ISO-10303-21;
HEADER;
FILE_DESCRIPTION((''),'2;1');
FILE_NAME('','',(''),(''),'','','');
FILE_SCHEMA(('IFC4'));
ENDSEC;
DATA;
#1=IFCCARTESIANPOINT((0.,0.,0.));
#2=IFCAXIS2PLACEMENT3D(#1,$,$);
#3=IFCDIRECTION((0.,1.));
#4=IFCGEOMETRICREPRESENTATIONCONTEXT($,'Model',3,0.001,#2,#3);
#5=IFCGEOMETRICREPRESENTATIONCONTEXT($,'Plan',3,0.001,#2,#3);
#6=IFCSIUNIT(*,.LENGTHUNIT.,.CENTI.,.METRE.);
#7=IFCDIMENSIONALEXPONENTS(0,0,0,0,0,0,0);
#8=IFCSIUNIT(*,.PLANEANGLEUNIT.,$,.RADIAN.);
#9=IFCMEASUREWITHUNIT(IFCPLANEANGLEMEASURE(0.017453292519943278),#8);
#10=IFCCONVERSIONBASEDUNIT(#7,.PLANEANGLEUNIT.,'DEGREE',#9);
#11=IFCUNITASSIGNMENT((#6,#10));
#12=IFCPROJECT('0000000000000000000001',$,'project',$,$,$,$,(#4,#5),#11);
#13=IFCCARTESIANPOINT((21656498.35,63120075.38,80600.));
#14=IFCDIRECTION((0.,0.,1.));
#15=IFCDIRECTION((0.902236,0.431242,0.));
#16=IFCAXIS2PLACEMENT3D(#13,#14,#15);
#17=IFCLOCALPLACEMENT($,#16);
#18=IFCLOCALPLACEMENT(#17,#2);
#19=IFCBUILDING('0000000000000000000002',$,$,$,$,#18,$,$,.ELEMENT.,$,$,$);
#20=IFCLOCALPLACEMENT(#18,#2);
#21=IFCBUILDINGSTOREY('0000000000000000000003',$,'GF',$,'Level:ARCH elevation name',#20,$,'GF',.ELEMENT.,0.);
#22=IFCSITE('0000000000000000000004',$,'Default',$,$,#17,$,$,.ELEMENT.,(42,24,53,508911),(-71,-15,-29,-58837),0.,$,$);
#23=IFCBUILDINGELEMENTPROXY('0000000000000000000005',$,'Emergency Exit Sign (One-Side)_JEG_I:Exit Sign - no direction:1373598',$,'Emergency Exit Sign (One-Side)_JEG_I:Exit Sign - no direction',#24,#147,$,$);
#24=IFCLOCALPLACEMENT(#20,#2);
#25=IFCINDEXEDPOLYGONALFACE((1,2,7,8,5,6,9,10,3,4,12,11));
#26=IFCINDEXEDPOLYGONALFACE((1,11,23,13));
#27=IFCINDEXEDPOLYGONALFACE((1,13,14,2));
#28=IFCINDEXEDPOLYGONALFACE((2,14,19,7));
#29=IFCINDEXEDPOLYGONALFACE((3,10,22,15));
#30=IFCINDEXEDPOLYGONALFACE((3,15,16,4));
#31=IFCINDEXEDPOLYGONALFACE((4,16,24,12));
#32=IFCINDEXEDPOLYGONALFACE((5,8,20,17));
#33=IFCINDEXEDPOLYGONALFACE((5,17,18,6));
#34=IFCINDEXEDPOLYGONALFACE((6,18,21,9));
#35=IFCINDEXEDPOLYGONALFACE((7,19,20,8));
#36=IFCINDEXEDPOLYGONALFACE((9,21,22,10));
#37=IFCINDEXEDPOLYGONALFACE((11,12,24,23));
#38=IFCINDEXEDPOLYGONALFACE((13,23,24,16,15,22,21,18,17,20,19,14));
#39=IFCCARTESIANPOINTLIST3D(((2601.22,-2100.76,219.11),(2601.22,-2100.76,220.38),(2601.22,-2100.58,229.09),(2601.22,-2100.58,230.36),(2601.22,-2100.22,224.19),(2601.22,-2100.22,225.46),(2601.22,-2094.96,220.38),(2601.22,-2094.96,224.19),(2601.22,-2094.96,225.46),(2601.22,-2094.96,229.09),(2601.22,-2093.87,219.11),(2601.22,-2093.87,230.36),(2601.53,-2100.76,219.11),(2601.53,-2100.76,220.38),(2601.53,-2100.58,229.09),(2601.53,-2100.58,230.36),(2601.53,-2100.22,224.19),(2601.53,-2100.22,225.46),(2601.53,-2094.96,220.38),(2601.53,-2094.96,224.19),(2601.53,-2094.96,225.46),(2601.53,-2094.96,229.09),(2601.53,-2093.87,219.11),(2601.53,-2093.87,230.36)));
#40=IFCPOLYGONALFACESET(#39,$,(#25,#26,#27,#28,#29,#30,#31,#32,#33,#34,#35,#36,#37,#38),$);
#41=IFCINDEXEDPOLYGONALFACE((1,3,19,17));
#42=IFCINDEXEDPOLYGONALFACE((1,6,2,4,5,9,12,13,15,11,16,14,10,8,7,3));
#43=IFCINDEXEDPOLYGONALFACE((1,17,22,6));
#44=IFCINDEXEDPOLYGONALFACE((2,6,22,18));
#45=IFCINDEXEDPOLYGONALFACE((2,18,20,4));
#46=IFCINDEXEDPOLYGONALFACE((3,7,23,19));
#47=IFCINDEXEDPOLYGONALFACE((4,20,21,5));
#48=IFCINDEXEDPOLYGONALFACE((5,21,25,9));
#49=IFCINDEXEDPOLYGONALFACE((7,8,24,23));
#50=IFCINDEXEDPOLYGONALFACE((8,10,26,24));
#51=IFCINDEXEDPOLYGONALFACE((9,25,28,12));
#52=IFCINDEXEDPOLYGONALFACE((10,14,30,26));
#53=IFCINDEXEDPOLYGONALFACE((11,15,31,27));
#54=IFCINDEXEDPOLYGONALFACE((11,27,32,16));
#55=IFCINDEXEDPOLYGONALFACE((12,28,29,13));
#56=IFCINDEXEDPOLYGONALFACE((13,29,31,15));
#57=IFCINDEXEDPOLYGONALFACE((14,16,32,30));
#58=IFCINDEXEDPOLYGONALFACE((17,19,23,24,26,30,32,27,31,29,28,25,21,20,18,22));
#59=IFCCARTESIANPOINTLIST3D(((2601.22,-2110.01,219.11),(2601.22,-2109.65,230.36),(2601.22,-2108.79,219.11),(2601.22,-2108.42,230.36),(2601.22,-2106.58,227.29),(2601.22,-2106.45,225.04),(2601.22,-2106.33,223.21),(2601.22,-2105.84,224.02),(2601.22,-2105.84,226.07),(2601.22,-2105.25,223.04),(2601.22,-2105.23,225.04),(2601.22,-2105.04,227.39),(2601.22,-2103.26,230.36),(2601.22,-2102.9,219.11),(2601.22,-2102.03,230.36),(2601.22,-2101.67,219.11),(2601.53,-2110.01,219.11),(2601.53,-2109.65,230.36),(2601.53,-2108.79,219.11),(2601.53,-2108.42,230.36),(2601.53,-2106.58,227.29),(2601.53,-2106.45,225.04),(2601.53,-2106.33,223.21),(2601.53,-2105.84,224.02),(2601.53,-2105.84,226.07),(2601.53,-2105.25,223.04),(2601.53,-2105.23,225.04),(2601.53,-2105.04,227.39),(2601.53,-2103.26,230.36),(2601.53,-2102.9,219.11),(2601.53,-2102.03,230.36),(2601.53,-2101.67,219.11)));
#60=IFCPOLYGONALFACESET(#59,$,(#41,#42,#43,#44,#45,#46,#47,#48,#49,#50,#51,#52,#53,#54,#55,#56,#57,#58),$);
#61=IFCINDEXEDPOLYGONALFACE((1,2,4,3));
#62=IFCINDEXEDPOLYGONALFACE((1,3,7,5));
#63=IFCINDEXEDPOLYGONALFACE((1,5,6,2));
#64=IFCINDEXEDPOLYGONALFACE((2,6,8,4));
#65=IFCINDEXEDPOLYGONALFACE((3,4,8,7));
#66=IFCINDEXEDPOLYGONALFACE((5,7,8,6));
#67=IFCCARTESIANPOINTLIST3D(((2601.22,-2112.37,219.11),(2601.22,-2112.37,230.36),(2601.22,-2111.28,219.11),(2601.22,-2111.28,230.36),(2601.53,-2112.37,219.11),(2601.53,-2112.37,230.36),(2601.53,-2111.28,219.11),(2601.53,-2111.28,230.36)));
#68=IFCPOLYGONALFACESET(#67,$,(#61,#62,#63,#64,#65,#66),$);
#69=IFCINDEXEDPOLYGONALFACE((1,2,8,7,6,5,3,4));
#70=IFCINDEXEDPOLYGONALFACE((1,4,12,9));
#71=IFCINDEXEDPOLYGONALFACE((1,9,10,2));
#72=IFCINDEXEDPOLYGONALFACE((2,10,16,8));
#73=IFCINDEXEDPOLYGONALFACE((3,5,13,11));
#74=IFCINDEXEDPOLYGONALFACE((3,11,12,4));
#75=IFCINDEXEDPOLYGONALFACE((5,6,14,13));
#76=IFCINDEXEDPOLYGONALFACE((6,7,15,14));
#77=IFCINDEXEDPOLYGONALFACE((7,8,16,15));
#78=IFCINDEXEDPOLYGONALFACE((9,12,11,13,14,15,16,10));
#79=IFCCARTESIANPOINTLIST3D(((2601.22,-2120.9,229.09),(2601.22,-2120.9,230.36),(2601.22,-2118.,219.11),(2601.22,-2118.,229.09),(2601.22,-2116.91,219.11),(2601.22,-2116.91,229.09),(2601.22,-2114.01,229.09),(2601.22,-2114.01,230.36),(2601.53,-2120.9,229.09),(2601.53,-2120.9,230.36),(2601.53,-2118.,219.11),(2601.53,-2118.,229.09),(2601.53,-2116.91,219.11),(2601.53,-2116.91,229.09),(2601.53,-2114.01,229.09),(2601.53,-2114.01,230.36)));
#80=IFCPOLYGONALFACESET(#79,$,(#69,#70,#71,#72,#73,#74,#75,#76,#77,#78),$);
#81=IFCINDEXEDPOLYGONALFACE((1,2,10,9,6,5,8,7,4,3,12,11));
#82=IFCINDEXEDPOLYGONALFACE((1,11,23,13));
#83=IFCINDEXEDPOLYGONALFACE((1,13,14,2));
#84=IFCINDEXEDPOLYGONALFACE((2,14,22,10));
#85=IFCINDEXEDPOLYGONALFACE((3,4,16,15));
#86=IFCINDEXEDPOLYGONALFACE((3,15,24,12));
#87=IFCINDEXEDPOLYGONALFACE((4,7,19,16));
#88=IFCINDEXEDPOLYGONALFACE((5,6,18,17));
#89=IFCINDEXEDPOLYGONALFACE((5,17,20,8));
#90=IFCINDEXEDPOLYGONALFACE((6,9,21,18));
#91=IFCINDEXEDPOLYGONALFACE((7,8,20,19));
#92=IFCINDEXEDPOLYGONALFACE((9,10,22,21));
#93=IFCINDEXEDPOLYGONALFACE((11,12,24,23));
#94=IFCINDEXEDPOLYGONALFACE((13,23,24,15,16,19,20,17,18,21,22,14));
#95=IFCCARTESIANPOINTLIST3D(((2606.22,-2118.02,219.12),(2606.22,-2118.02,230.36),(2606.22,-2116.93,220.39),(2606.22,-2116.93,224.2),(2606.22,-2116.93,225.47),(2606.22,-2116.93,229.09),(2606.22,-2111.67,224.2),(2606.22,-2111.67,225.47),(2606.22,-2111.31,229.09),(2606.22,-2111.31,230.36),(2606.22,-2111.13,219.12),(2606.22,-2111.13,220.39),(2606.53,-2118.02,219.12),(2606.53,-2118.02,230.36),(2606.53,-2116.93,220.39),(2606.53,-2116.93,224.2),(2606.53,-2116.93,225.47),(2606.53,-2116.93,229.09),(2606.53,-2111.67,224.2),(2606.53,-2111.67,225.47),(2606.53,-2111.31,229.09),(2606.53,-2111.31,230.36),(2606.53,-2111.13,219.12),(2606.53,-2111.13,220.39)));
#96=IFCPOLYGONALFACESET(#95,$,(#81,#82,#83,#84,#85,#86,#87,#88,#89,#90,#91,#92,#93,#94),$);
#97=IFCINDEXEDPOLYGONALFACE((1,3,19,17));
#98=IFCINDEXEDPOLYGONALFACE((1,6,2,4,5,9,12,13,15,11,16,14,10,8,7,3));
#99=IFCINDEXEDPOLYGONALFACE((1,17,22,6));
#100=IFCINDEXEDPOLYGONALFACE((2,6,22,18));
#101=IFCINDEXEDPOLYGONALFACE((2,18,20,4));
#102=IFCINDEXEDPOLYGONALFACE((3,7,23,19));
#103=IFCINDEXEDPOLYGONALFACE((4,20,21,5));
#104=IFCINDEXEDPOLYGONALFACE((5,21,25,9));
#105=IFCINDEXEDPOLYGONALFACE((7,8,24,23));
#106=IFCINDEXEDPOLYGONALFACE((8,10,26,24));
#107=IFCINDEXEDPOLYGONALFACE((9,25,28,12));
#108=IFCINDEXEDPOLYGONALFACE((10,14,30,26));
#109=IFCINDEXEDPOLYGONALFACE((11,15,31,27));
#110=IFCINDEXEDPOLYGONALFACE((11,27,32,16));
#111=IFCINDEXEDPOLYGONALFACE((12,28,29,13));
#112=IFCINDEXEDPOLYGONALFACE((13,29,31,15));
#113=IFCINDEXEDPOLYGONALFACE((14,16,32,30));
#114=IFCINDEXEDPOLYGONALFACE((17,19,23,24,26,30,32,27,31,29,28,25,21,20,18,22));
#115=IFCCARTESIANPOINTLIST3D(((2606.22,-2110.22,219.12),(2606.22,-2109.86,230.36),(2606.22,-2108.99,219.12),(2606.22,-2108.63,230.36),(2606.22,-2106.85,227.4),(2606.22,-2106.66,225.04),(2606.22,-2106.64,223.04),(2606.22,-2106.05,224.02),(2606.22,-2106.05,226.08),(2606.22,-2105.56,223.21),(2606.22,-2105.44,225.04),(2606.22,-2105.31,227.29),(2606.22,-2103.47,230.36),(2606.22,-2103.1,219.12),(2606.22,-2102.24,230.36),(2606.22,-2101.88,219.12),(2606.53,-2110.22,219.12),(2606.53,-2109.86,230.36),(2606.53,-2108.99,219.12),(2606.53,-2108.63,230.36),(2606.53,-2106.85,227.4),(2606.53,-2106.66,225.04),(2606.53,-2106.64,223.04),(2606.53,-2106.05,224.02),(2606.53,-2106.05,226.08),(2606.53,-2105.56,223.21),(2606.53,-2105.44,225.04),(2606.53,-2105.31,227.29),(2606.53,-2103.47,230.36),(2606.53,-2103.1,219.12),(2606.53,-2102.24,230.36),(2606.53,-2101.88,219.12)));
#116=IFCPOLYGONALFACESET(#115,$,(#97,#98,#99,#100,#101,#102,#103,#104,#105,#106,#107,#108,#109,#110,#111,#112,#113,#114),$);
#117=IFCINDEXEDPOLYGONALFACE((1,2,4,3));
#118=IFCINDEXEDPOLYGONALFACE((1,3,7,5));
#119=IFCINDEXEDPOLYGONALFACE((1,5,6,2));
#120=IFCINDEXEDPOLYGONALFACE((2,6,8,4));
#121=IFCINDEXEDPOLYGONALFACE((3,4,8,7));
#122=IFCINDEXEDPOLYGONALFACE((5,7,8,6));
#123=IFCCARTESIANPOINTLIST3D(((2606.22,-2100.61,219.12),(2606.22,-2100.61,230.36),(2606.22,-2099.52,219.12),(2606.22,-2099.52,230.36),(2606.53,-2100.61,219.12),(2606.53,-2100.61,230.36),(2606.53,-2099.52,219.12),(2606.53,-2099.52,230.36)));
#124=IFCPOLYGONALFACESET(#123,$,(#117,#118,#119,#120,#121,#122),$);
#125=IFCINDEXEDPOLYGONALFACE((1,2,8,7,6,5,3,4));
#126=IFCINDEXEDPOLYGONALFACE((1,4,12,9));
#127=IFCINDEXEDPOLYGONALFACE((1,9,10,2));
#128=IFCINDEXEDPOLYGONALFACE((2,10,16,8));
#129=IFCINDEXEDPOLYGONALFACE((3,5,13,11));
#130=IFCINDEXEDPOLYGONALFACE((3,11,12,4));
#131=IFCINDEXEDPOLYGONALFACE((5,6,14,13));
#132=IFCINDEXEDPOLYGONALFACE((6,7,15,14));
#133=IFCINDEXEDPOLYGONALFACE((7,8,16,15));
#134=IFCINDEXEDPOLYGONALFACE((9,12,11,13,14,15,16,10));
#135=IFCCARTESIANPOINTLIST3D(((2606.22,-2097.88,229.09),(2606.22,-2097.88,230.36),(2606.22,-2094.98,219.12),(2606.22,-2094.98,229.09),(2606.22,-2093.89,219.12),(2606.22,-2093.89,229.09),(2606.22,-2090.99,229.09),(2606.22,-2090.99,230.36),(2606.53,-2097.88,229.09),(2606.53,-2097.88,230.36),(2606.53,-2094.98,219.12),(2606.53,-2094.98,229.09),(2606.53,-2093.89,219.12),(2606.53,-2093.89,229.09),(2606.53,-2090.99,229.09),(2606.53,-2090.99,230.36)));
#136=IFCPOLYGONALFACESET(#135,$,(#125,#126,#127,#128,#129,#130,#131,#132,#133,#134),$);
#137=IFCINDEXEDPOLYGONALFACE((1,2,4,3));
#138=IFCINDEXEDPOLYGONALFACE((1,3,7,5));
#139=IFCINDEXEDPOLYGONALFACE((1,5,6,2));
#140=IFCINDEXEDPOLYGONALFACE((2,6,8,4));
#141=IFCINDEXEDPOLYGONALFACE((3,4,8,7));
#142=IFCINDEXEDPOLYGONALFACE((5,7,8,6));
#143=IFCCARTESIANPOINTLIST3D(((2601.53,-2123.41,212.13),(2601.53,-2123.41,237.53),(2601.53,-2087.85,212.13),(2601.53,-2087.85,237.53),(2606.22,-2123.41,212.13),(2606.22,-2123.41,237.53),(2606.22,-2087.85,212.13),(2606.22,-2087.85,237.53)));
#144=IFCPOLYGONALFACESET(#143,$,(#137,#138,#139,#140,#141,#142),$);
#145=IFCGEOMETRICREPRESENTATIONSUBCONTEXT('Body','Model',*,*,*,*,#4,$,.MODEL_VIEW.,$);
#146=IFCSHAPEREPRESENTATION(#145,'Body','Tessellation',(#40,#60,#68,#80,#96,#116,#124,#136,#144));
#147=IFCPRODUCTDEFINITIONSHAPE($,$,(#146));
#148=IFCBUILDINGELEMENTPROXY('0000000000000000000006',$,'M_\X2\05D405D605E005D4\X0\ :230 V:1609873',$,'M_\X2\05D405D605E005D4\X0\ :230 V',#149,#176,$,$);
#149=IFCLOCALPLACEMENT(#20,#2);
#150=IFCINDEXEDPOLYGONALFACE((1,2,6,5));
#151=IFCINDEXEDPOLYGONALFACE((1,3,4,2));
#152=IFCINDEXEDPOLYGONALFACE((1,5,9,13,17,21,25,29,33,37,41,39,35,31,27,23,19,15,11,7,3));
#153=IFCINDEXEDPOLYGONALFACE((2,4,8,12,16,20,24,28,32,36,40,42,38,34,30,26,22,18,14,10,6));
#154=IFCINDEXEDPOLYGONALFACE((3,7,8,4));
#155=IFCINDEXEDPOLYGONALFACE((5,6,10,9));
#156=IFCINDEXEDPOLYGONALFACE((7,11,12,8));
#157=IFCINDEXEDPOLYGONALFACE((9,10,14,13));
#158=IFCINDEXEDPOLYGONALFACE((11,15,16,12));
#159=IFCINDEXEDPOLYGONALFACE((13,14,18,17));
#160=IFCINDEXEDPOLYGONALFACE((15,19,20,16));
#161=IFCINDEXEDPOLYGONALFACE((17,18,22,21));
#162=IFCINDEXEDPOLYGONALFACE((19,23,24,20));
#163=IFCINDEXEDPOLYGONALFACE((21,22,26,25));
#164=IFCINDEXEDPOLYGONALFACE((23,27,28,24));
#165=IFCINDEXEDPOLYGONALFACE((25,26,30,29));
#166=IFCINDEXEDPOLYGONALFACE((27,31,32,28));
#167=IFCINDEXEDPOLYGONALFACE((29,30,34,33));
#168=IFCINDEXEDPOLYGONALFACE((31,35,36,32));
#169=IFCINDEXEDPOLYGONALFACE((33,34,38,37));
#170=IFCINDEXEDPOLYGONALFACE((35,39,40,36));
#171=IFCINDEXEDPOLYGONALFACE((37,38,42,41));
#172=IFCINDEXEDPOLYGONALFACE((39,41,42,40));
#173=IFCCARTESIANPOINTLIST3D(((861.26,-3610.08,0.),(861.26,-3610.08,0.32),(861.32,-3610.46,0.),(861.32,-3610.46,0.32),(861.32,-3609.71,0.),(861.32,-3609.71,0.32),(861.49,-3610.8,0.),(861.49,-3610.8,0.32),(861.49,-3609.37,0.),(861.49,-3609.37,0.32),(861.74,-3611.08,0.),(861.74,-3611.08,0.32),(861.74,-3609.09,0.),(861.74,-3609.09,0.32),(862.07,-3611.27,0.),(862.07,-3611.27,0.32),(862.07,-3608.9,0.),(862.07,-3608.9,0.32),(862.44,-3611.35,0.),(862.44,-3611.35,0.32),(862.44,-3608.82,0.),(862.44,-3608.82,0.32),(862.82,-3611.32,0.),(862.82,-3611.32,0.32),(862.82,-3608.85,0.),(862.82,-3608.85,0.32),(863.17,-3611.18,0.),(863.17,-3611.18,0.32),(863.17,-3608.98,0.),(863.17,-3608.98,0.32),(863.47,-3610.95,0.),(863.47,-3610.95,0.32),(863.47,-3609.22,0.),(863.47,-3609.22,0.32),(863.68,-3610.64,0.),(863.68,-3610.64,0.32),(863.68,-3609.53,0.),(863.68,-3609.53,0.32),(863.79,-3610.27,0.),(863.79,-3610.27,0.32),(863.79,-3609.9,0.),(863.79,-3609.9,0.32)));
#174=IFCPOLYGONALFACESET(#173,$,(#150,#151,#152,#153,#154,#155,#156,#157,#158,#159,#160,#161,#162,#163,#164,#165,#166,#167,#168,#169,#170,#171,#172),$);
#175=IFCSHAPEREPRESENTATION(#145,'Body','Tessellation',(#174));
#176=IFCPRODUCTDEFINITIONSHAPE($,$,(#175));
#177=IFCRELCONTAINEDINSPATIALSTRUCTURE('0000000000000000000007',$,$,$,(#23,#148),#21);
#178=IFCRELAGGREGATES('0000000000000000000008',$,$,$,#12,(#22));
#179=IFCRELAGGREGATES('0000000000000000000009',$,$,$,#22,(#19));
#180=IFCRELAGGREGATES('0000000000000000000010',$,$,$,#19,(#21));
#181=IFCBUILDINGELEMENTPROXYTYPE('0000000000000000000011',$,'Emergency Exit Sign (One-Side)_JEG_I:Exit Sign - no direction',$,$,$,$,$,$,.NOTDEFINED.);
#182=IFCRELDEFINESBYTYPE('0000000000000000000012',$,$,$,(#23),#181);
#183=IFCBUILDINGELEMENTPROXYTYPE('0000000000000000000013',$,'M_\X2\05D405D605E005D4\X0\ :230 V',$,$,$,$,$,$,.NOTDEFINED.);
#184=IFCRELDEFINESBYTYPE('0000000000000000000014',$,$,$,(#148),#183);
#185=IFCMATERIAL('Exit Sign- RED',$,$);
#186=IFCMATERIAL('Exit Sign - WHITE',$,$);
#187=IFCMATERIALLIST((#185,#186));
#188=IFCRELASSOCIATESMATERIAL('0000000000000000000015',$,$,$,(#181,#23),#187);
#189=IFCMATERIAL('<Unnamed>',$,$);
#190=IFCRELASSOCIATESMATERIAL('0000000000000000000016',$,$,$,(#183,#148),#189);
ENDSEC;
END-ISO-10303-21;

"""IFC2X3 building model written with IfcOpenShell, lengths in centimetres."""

from ifc_helpers import new_model, entity, si_unit, converted_unit, direction, frame, frame_2d, origin, origin_2d_with_axis, place, context, subcontext, project, spatial, polyline, rectangle, circle, outline, extrude, source, transform, mapped, material, material_list, type_object, type_shapes, element, save


model = new_model("IFC2X3")

# Units and contexts
model_context = context("Model", 3, precision=0.001, world=origin(), true_north=direction((0.0, 1.0)))
plan_context = context("Plan", 3, precision=0.001, world=origin(), true_north=direction((0.0, 1.0)))
body_context = subcontext(model_context, "Body", "Model", "MODEL_VIEW")
ifc_project = project(units=[si_unit("LENGTHUNIT", "METRE", prefix="CENTI"), converted_unit("PLANEANGLEUNIT", "DEGREE", entity("IfcPlaneAngleMeasure", 0.017453292519943278), si_unit("PLANEANGLEUNIT", "RADIAN"), dimensions=[0, 0, 0, 0, 0, 0, 0])], contexts=[model_context, plan_context])

# Site, building, storey
site_placement = place(None, frame((21656498.35, 63120075.38, 80600.0), z_axis=(0.0, 0.0, 1.0), x_axis=(0.902236, 0.431242, 0.0)))
site = spatial("IfcSite", under=ifc_project, at=site_placement, Name="Default", CompositionType="ELEMENT", RefLatitude=(42, 24, 53, 508911), RefLongitude=(-71, -15, -29, -58837), RefElevation=0.0)
building_placement = place(site_placement, origin())
building = spatial("IfcBuilding", under=site, at=building_placement, CompositionType="ELEMENT")
storey_placement = place(building_placement, origin())
storey = spatial("IfcBuildingStorey", under=building, at=storey_placement, Name="GF", ObjectType="Level:ARCH elevation name", LongName="GF", CompositionType="ELEMENT", Elevation=0.0)

# Shared definitions
ifc_material_1 = material(Name="Exit Sign - WHITE")
ifc_material_2 = material(Name="Exit Sign- RED")

# Building element proxies
ifc_material_3 = material(Name="<Unnamed>")
ifc_material_list_1 = material_list([ifc_material_2, ifc_material_1])
building_element_proxy_type_1 = type_object("IfcBuildingElementProxyType", Name="Emergency Exit Sign (One-Side)_JEG_I:Exit Sign - no direction", PredefinedType="NOTDEFINED", material=ifc_material_list_1)
shared_shape_1 = source(origin(), body_context, "Body", "SweptSolid", [
    extrude(outline(polyline([(-5.65, -3.69), (5.59, -3.69), (5.59, 3.02), (4.32, 3.02), (4.32, -2.6), (0.7, -2.6), (0.7, 2.66), (-0.57, 2.66), (-0.57, -2.6), (-4.38, -2.6), (-4.38, 3.21), (-5.65, 3.21), (-5.65, -3.69)])), frame((-8.08, -5.22, 12.64), z_axis=(0.0, 1.0, 0.0), x_axis=(0.0, 0.0, 1.0)), (0.0, 0.0, 1.0), 0.32),
    extrude(outline(polyline([(-7.14, 0.57), (-6.5, -0.49), (-1.93, -0.48), (-0.78, -0.48), (-1.23, -1.32), (-3.47, -5.53), (-2.84, -6.59), (0.41, -0.48), (6.62, -0.48), (5.99, 0.57), (2.4, 0.57), (0.98, 0.58), (1.7, 1.94), (3.32, 5.0), (2.69, 6.05), (-0.22, 0.57), (-7.14, 0.57)])), frame((0.2, -5.22, 12.81), z_axis=(0.0, -1.0, 0.0), x_axis=(0.515099, 0.0, 0.857131)), (0.0, 0.0, -1.0), 0.32),
    extrude(rectangle(XDim=0.32, YDim=1.09, at=frame_2d((0.0, 0.0), x_axis=(1.0, 0.0))), frame((6.19, -5.06, 6.99), z_axis=(0.0, 0.0, 1.0), x_axis=(0.0, 1.0, 0.0)), (0.0, 0.0, 1.0), 11.25),
    extrude(outline(polyline([(-7.8, 0.54), (-7.8, -0.54), (2.18, -0.54), (2.18, -3.45), (3.45, -3.45), (3.45, 3.45), (2.18, 3.45), (2.18, 0.54), (-7.8, 0.54)])), frame((11.82, -5.22, 14.79), z_axis=(0.0, -1.0, 0.0), x_axis=(0.0, 0.0, 1.0)), (0.0, 0.0, -1.0), 0.32),
    extrude(outline(polyline([(-3.69, -5.65), (3.21, -5.65), (3.21, -4.38), (-2.6, -4.38), (-2.6, -0.57), (2.66, -0.57), (2.66, 0.7), (-2.6, 0.7), (-2.6, 4.32), (3.02, 4.32), (3.02, 5.59), (-3.69, 5.59), (-3.69, -5.65)])), frame((8.7, -0.22, 12.65), z_axis=(0.0, 1.0, 0.0), x_axis=(-1.0, 0.0, 0.0)), (0.0, 0.0, 1.0), 0.32),
    extrude(outline(polyline([(-4.16, -5.82), (-2.93, -5.82), (-0.58, -1.9), (0.01, -0.92), (0.5, -1.73), (2.96, -5.82), (4.18, -5.82), (0.62, 0.1), (3.82, 5.42), (2.59, 5.42), (0.75, 2.35), (0.01, 1.14), (-0.79, 2.46), (-2.57, 5.42), (-3.8, 5.42), (-0.6, 0.1), (-4.16, -5.82)])), frame((0.43, -0.22, 12.82), z_axis=(0.0, 1.0, 0.0), x_axis=(-1.0, 0.0, 0.0)), (0.0, 0.0, 1.0), 0.32),
    extrude(rectangle(XDim=0.32, YDim=1.09, at=origin_2d_with_axis()), frame((-5.57, -0.06, 6.99), z_axis=(0.0, 0.0, 1.0), x_axis=(0.0, -1.0, 0.0)), (0.0, 0.0, 1.0), 11.25),
    extrude(outline(polyline([(-0.54, -7.8), (0.54, -7.8), (0.54, 2.18), (3.45, 2.18), (3.45, 3.45), (-3.45, 3.45), (-3.45, 2.18), (-0.54, 2.18), (-0.54, -7.8)])), frame((-11.2, -0.22, 14.79), z_axis=(0.0, 1.0, 0.0), x_axis=(-1.0, 0.0, 0.0)), (0.0, 0.0, 1.0), 0.32),
    extrude(rectangle(XDim=4.68, YDim=35.56, at=origin_2d_with_axis()), frame((0.0, -2.56, 0.01), z_axis=(0.0, 0.0, 1.0), x_axis=(0.0, 1.0, 0.0)), (0.0, 0.0, 1.0), 25.4),
])
type_shapes(building_element_proxy_type_1, [shared_shape_1])
for number, where, z_axis, x_axis, name in (
    (1, (2606.44, -2105.63, 212.12), (0.0, 0.0, 1.0), (0.0, -1.0, 0.0), "Emergency Exit Sign (One-Side)_JEG_I:Exit Sign - no direction:1373598"),
):
    element("IfcBuildingElementProxy", number, at=place(storey_placement, frame(where, z_axis=z_axis, x_axis=x_axis)), inside=storey, type_object=building_element_proxy_type_1, material=ifc_material_list_1, Name=name, ObjectType="Emergency Exit Sign (One-Side)_JEG_I:Exit Sign - no direction", context=body_context, shape_type="MappedRepresentation", body=[
        mapped(shared_shape_1, transform((0.0, 0.0, 0.0), scale=1.0)),
    ])
building_element_proxy_type_2 = type_object("IfcBuildingElementProxyType", Name="M_הזנה :230 V", PredefinedType="NOTDEFINED", material=ifc_material_3)
shared_shape_2 = source(origin(), body_context, "Body", "SweptSolid", [
    extrude(circle(Radius=1.27, at=frame_2d((0.0, 0.0), x_axis=(1.0, 0.0))), origin(), (0.0, 0.0, 1.0), 0.32),
])
type_shapes(building_element_proxy_type_2, [shared_shape_2])
for number, where, z_axis, x_axis, name in (
    (2, (862.53, -3610.08, 0.0), (0.0, 0.0, 1.0), (-1.0, 0.0, 0.0), "M_הזנה :230 V:1609873"),
):
    element("IfcBuildingElementProxy", number, at=place(storey_placement, frame(where, z_axis=z_axis, x_axis=x_axis)), inside=storey, type_object=building_element_proxy_type_2, material=ifc_material_3, Name=name, ObjectType="M_הזנה :230 V", context=body_context, shape_type="MappedRepresentation", body=[
        mapped(shared_shape_2, transform((0.0, 0.0, 0.0), scale=1.0)),
    ])

save(model, "model.ifc")
